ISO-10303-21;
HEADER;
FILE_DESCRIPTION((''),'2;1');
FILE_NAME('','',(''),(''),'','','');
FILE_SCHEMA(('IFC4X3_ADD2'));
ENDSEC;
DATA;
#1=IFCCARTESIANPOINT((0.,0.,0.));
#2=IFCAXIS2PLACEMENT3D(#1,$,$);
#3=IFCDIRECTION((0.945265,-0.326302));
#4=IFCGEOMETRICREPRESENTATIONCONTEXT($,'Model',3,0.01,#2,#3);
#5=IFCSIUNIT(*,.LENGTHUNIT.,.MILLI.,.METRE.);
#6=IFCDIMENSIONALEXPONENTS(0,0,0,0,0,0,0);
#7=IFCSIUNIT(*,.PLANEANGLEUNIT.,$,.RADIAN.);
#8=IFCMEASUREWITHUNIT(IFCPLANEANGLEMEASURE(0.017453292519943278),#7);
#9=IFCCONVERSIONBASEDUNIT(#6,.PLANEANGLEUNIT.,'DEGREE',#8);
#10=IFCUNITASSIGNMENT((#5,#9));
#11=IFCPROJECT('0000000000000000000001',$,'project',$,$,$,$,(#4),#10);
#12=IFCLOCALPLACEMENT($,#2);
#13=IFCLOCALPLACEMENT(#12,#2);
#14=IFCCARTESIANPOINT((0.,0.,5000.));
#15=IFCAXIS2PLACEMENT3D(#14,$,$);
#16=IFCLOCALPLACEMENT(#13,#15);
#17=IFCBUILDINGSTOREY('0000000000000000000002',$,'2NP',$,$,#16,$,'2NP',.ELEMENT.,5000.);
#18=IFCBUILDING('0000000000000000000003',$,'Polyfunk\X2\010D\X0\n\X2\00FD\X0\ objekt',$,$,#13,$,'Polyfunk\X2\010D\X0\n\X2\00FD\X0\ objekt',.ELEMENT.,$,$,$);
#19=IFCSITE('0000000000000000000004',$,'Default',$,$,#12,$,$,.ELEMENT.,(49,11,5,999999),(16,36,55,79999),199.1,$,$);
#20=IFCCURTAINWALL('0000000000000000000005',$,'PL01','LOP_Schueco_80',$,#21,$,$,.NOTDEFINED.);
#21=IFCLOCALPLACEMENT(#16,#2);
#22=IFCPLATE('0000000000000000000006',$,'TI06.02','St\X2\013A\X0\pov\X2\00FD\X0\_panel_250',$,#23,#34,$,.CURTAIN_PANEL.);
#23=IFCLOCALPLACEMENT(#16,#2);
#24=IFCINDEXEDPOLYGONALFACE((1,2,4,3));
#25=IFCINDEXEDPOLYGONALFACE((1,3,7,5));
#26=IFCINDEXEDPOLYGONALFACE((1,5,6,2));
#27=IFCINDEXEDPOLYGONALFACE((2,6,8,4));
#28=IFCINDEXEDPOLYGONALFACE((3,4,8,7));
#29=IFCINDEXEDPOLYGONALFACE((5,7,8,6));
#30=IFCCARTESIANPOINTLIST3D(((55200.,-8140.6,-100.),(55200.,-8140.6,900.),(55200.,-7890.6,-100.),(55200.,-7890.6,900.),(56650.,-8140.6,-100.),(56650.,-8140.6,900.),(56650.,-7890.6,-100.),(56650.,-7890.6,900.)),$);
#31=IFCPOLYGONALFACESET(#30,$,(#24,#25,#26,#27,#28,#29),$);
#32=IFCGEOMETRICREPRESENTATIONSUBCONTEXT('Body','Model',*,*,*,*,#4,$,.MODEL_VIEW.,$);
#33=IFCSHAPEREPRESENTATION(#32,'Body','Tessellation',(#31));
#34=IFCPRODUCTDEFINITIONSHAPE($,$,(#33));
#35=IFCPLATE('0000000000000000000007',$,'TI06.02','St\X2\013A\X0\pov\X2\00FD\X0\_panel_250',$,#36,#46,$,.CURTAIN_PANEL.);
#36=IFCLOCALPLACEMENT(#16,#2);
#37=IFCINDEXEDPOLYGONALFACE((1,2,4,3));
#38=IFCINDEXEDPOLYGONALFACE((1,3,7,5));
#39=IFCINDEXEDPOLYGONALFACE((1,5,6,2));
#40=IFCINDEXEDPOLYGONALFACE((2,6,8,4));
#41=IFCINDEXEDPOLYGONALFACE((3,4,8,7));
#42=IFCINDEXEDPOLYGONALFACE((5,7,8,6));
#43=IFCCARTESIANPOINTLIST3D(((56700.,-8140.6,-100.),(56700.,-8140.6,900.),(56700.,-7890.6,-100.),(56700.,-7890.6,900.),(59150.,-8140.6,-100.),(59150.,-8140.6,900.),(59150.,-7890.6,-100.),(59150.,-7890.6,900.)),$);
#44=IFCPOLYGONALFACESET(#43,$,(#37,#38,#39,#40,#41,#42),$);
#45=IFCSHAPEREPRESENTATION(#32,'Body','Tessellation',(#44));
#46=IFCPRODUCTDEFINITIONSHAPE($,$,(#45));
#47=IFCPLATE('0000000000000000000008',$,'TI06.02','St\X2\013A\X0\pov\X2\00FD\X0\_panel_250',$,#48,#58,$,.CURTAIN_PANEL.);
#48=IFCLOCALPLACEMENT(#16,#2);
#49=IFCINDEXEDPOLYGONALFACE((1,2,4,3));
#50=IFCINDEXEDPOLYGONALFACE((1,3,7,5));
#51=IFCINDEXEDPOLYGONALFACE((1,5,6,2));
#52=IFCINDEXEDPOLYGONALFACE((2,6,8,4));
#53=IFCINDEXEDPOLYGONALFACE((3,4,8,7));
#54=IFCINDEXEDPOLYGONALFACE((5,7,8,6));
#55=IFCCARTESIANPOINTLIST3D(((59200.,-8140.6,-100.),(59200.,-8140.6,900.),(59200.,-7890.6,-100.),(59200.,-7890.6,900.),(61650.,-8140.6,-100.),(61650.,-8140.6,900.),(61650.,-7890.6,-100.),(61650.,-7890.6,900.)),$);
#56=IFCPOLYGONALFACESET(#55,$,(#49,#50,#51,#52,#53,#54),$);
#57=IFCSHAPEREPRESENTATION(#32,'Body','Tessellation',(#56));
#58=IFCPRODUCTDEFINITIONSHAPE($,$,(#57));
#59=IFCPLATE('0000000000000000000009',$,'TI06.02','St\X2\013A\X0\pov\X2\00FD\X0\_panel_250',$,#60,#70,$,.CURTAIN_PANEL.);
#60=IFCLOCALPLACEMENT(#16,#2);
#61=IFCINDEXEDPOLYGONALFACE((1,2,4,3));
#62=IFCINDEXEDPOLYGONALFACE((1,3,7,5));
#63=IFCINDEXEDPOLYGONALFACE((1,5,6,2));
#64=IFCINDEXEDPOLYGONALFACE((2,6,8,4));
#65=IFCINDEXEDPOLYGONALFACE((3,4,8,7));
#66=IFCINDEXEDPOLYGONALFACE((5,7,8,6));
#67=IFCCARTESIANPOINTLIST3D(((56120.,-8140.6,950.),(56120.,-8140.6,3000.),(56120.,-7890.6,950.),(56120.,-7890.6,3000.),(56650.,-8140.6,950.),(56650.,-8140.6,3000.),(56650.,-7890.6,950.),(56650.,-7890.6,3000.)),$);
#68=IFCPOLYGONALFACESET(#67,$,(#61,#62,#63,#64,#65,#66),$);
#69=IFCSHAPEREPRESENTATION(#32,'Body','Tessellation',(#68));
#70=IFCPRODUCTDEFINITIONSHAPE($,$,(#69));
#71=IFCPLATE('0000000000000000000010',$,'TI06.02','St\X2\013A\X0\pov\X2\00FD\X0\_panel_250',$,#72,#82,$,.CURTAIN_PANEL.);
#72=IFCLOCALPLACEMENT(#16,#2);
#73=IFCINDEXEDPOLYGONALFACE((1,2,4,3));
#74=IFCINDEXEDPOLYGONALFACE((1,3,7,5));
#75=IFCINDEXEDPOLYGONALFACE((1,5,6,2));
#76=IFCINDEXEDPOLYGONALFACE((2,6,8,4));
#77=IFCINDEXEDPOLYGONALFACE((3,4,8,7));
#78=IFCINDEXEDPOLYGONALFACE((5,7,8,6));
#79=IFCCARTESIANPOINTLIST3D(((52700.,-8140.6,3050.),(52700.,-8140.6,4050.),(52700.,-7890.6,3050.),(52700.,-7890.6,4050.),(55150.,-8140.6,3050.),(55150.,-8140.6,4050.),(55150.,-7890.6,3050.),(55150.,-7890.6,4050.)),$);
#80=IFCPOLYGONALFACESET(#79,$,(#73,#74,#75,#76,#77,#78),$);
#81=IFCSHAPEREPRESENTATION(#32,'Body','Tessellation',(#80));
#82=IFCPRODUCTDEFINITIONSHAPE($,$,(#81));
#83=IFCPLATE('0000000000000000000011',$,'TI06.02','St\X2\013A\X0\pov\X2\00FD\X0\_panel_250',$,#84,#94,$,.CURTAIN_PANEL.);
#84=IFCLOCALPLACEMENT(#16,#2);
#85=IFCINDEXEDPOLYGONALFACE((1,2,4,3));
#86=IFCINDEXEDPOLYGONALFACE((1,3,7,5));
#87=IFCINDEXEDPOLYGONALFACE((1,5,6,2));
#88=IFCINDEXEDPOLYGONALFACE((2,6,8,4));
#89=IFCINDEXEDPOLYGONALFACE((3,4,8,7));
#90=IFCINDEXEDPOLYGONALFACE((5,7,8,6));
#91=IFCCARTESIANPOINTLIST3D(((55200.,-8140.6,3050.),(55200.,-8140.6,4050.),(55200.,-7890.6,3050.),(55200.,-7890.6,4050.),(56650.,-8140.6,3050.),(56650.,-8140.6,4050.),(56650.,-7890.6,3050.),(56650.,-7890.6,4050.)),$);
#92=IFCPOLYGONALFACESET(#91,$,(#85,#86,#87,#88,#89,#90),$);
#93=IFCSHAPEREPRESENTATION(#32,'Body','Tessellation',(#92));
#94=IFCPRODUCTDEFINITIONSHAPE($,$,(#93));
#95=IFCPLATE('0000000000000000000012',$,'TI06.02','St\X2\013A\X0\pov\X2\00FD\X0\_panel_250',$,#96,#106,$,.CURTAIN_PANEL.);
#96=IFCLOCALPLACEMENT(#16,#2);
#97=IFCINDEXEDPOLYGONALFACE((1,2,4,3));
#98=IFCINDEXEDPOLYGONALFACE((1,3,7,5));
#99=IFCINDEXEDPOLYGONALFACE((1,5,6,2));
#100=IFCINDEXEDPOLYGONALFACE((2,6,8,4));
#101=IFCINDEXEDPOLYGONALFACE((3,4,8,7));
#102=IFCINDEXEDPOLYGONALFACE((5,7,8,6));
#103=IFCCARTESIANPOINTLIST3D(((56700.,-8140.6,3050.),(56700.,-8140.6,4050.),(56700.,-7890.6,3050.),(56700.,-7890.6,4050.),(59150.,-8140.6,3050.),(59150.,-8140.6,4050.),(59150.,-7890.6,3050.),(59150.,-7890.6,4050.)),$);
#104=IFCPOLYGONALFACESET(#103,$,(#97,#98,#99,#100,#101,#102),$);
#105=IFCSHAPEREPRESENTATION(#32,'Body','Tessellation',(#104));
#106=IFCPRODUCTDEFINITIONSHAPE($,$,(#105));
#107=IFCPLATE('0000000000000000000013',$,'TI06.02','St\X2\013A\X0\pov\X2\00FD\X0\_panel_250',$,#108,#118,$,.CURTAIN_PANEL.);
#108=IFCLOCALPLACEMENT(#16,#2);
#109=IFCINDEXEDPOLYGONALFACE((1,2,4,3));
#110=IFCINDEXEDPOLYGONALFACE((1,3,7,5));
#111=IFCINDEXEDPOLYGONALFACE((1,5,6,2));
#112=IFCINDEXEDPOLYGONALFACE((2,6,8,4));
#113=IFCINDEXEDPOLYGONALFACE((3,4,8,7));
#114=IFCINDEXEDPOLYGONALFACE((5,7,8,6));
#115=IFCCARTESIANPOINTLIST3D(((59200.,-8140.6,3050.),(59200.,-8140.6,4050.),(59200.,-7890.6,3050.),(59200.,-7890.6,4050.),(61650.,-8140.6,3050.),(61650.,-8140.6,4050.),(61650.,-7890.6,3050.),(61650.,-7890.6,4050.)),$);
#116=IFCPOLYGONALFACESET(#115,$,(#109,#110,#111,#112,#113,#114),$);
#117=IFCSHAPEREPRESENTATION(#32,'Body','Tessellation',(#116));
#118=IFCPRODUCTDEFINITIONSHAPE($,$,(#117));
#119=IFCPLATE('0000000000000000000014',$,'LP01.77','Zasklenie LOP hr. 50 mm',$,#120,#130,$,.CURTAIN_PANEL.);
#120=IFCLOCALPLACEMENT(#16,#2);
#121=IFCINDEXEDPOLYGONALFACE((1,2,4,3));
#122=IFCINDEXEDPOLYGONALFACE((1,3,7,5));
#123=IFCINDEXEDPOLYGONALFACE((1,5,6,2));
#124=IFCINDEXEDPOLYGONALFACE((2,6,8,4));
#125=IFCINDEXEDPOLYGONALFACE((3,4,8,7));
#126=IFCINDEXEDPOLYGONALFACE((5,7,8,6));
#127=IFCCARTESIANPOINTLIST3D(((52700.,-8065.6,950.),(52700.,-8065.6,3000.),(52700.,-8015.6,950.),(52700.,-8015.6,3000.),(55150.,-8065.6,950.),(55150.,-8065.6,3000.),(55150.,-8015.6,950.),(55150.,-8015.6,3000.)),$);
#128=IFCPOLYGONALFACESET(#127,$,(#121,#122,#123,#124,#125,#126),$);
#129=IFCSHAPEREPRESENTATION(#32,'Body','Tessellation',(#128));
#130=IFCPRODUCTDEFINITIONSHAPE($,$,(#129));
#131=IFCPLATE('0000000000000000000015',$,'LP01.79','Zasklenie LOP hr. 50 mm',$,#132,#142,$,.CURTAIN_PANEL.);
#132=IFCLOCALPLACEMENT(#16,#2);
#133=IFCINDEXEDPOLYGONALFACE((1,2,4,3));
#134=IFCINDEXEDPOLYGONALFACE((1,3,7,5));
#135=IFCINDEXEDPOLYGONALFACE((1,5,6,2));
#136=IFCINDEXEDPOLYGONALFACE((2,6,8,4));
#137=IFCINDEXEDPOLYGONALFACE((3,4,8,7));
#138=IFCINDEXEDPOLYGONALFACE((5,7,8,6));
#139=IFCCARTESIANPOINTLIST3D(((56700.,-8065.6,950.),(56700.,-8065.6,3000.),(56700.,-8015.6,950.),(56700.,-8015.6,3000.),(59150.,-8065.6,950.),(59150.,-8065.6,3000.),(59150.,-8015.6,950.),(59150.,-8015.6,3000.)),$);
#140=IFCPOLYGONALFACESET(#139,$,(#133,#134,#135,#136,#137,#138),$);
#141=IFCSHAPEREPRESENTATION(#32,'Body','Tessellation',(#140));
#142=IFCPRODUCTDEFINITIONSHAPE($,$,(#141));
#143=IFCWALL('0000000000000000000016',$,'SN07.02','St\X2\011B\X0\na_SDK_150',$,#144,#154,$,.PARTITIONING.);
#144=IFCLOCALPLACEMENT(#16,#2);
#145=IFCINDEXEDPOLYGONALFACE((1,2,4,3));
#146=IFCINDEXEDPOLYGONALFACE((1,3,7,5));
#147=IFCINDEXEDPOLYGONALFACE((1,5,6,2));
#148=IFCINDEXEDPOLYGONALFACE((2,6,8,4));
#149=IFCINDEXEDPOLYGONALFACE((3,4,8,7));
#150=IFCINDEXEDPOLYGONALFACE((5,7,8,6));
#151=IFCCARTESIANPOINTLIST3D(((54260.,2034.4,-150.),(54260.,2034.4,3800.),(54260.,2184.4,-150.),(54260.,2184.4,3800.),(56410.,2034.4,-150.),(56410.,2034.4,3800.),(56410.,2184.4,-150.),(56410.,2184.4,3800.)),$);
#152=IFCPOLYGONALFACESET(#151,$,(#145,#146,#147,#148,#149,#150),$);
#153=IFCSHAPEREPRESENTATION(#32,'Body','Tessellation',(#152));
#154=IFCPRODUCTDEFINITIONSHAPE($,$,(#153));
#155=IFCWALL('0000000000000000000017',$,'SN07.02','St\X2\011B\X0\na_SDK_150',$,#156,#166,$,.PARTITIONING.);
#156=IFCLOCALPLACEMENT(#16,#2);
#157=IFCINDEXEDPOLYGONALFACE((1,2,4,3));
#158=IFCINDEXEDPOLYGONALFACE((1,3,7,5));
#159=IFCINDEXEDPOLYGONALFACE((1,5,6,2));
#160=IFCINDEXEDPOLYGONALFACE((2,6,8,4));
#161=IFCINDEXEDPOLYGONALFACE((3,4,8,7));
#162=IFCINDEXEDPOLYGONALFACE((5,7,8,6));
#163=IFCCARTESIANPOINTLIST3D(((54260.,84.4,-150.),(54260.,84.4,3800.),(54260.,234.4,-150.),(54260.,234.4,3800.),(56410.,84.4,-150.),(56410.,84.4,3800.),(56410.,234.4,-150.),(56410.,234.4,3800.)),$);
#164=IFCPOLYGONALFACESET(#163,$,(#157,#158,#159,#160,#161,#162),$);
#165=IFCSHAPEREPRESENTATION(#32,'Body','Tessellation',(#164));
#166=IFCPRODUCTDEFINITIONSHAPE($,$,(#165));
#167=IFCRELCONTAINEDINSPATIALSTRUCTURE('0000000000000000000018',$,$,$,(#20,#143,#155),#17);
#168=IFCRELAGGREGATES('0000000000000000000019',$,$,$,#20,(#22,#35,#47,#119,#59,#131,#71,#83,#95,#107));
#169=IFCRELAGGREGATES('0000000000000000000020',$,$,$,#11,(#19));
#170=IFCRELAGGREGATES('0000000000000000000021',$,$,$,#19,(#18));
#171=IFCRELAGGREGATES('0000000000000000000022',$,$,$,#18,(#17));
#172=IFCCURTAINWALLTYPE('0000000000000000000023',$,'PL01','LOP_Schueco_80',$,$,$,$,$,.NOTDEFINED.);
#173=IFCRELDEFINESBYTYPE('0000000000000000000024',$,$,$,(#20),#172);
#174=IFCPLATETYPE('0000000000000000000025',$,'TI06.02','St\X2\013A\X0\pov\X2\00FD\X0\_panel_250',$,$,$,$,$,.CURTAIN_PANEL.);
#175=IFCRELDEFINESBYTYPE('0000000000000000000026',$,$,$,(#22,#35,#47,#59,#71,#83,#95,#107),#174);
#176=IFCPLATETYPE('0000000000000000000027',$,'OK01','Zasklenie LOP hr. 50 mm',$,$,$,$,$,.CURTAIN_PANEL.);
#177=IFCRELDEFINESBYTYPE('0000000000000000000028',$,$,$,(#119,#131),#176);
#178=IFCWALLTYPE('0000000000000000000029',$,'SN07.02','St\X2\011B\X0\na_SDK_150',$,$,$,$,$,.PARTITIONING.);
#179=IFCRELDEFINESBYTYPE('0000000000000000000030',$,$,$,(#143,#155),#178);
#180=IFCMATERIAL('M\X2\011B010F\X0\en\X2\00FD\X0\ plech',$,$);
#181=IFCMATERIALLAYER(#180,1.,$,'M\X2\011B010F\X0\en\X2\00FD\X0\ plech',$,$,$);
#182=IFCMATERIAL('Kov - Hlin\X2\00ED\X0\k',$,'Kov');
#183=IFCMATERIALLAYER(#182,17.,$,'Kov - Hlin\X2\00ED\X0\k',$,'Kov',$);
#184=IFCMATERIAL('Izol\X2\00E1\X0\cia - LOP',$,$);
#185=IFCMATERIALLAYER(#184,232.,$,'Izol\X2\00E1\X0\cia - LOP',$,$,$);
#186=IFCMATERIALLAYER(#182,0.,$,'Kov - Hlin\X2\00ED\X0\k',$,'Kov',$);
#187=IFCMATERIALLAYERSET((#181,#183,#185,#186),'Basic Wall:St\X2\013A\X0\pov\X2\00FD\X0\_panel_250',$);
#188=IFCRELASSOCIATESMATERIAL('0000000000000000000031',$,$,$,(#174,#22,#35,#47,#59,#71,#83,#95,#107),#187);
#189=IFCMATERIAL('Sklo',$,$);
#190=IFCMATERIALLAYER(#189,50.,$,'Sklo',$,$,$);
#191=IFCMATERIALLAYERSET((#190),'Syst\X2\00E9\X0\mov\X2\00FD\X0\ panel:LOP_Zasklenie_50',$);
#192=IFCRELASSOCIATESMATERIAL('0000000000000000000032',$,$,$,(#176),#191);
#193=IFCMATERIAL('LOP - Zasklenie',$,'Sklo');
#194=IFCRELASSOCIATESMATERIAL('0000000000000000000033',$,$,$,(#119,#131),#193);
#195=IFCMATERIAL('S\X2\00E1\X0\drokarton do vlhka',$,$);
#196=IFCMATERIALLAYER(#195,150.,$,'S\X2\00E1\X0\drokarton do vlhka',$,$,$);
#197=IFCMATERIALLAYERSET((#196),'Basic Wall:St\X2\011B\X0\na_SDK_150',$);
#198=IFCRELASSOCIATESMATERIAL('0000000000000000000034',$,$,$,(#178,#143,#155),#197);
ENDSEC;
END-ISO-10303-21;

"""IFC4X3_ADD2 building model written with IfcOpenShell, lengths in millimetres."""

from ifc_helpers import new_model, entity, si_unit, converted_unit, direction, frame, frame_2d, origin, origin_2d_with_axis, place, context, subcontext, project, spatial, polyline, rectangle, extrude, clip, bounded_halfspace, source, transform, mapped, material, layer, layer_set, layer_usage, type_object, type_shapes, element, aggregate, save


model = new_model("IFC4X3_ADD2")

# Units and contexts
model_context = context("Model", 3, precision=0.01, world=origin(), true_north=direction((0.945265, -0.326302)))
body_context = subcontext(model_context, "Body", "Model", "MODEL_VIEW")
ifc_project = project(units=[si_unit("LENGTHUNIT", "METRE", prefix="MILLI"), converted_unit("PLANEANGLEUNIT", "DEGREE", entity("IfcPlaneAngleMeasure", 0.017453292519943278), si_unit("PLANEANGLEUNIT", "RADIAN"), dimensions=[0, 0, 0, 0, 0, 0, 0])], contexts=[model_context])

# Site, building, storey
site_placement = place(None, origin())
site = spatial("IfcSite", under=ifc_project, at=site_placement, Name="Default", CompositionType="ELEMENT", RefLatitude=(49, 11, 5, 999999), RefLongitude=(16, 36, 55, 79999), RefElevation=199.1)
building_placement = place(site_placement, origin())
building = spatial("IfcBuilding", under=site, at=building_placement, Name="Polyfunkčný objekt", LongName="Polyfunkčný objekt", CompositionType="ELEMENT")
storey_placement = place(building_placement, frame((0.0, 0.0, 5000.0)))
storey = spatial("IfcBuildingStorey", under=building, at=storey_placement, Name="2NP", LongName="2NP", CompositionType="ELEMENT", Elevation=5000.0)

# Curtain wall, plates
curtain_wall_type = type_object("IfcCurtainWallType", Name="PL01", Description="LOP_Schueco_80", PredefinedType="NOTDEFINED")
curtain_wall_placement = place(storey_placement, frame((0.0, 0.0, -5000.0)))
curtain_wall = element("IfcCurtainWall", 1, at=curtain_wall_placement, inside=storey, type_object=curtain_wall_type, Name="PL01", Description="LOP_Schueco_80", PredefinedType="NOTDEFINED")
ifc_material_1 = material(Name="Měďený plech")
ifc_layer_1 = layer(ifc_material_1, 1.0, Name="Měďený plech")
ifc_material_2 = material(Name="Kov - Hliník", Category="Kov")
ifc_layer_2 = layer(ifc_material_2, 17.0, Name="Kov - Hliník", Category="Kov")
ifc_material_3 = material(Name="Izolácia - LOP")
ifc_layer_3 = layer(ifc_material_3, 232.0, Name="Izolácia - LOP")
ifc_layer_4 = layer(ifc_material_2, 0.0, Name="Kov - Hliník", Category="Kov")
ifc_layer_set_1 = layer_set([ifc_layer_1, ifc_layer_2, ifc_layer_3, ifc_layer_4], Name="Basic Wall:Stĺpový_panel_250")
ifc_layer_usage_1 = layer_usage(ifc_layer_set_1, "AXIS2", "POSITIVE", -125.0)
plate_type_1 = type_object("IfcPlateType", Name="TI06.02", Description="Stĺpový_panel_250", PredefinedType="CURTAIN_PANEL", material=ifc_layer_set_1)
plate_1_placement = place(storey_placement, frame((55200.0, -8015.6, -100.0)))
plate_1 = element("IfcPlate", 2, at=plate_1_placement, type_object=plate_type_1, material=ifc_layer_usage_1, Name="TI06.02", Description="Stĺpový_panel_250", PredefinedType="CURTAIN_PANEL", context=body_context, shape_type="SweptSolid", body=[
    extrude(rectangle(XDim=250.0, YDim=1450.0, at=frame_2d((0.0, 0.0), x_axis=(1.0, 0.0))), frame((725.0, 0.0, 0.0), z_axis=(0.0, 0.0, 1.0), x_axis=(0.0, 1.0, 0.0)), (0.0, 0.0, 1.0), 1000.0),
])
ifc_layer_usage_2 = layer_usage(ifc_layer_set_1, "AXIS2", "POSITIVE", -125.0)
plate_2_placement = place(storey_placement, frame((56700.0, -8015.6, -100.0)))
plate_2 = element("IfcPlate", 3, at=plate_2_placement, type_object=plate_type_1, material=ifc_layer_usage_2, Name="TI06.02", Description="Stĺpový_panel_250", PredefinedType="CURTAIN_PANEL", context=body_context, shape_type="SweptSolid", body=[
    extrude(rectangle(XDim=250.0, YDim=2450.0, at=frame_2d((0.0, 0.0), x_axis=(1.0, 0.0))), frame((1225.0, 0.0, 0.0), z_axis=(0.0, 0.0, 1.0), x_axis=(0.0, 1.0, 0.0)), (0.0, 0.0, 1.0), 1000.0),
])
ifc_layer_usage_3 = layer_usage(ifc_layer_set_1, "AXIS2", "POSITIVE", -125.0)
plate_3_placement = place(storey_placement, frame((59200.0, -8015.6, -100.0)))
plate_3 = element("IfcPlate", 4, at=plate_3_placement, type_object=plate_type_1, material=ifc_layer_usage_3, Name="TI06.02", Description="Stĺpový_panel_250", PredefinedType="CURTAIN_PANEL", context=body_context, shape_type="SweptSolid", body=[
    extrude(rectangle(XDim=250.0, YDim=2450.0, at=frame_2d((0.0, 0.0), x_axis=(1.0, 0.0))), frame((1225.0, 0.0, 0.0), z_axis=(0.0, 0.0, 1.0), x_axis=(0.0, 1.0, 0.0)), (0.0, 0.0, 1.0), 1000.0),
])
ifc_layer_usage_4 = layer_usage(ifc_layer_set_1, "AXIS2", "POSITIVE", -125.0)
plate_4_placement = place(storey_placement, frame((56120.0, -8015.6, 950.0)))
plate_4 = element("IfcPlate", 5, at=plate_4_placement, type_object=plate_type_1, material=ifc_layer_usage_4, Name="TI06.02", Description="Stĺpový_panel_250", PredefinedType="CURTAIN_PANEL", context=body_context, shape_type="SweptSolid", body=[
    extrude(rectangle(XDim=250.0, YDim=530.0, at=origin_2d_with_axis()), frame((265.0, 0.0, 0.0), z_axis=(0.0, 0.0, 1.0), x_axis=(0.0, 1.0, 0.0)), (0.0, 0.0, 1.0), 2050.0),
])
ifc_layer_usage_5 = layer_usage(ifc_layer_set_1, "AXIS2", "POSITIVE", -125.0)
plate_5_placement = place(storey_placement, frame((52700.0, -8015.6, 3050.0)))
plate_5 = element("IfcPlate", 6, at=plate_5_placement, type_object=plate_type_1, material=ifc_layer_usage_5, Name="TI06.02", Description="Stĺpový_panel_250", PredefinedType="CURTAIN_PANEL", context=body_context, shape_type="SweptSolid", body=[
    extrude(rectangle(XDim=250.0, YDim=2450.0, at=frame_2d((0.0, 0.0), x_axis=(1.0, 0.0))), frame((1225.0, 0.0, 0.0), z_axis=(0.0, 0.0, 1.0), x_axis=(0.0, 1.0, 0.0)), (0.0, 0.0, 1.0), 1000.0),
])
ifc_layer_usage_6 = layer_usage(ifc_layer_set_1, "AXIS2", "POSITIVE", -125.0)
plate_6_placement = place(storey_placement, frame((55200.0, -8015.6, 3050.0)))
plate_6 = element("IfcPlate", 7, at=plate_6_placement, type_object=plate_type_1, material=ifc_layer_usage_6, Name="TI06.02", Description="Stĺpový_panel_250", PredefinedType="CURTAIN_PANEL", context=body_context, shape_type="SweptSolid", body=[
    extrude(rectangle(XDim=250.0, YDim=1450.0, at=frame_2d((0.0, 0.0), x_axis=(1.0, 0.0))), frame((725.0, 0.0, 0.0), z_axis=(0.0, 0.0, 1.0), x_axis=(0.0, 1.0, 0.0)), (0.0, 0.0, 1.0), 1000.0),
])
ifc_layer_usage_7 = layer_usage(ifc_layer_set_1, "AXIS2", "POSITIVE", -125.0)
plate_7_placement = place(storey_placement, frame((56700.0, -8015.6, 3050.0)))
plate_7 = element("IfcPlate", 8, at=plate_7_placement, type_object=plate_type_1, material=ifc_layer_usage_7, Name="TI06.02", Description="Stĺpový_panel_250", PredefinedType="CURTAIN_PANEL", context=body_context, shape_type="SweptSolid", body=[
    extrude(rectangle(XDim=250.0, YDim=2450.0, at=frame_2d((0.0, 0.0), x_axis=(1.0, 0.0))), frame((1225.0, 0.0, 0.0), z_axis=(0.0, 0.0, 1.0), x_axis=(0.0, 1.0, 0.0)), (0.0, 0.0, 1.0), 1000.0),
])
ifc_layer_usage_8 = layer_usage(ifc_layer_set_1, "AXIS2", "POSITIVE", -125.0)
plate_8_placement = place(storey_placement, frame((59200.0, -8015.6, 3050.0)))
plate_8 = element("IfcPlate", 9, at=plate_8_placement, type_object=plate_type_1, material=ifc_layer_usage_8, Name="TI06.02", Description="Stĺpový_panel_250", PredefinedType="CURTAIN_PANEL", context=body_context, shape_type="SweptSolid", body=[
    extrude(rectangle(XDim=250.0, YDim=2450.0, at=frame_2d((0.0, 0.0), x_axis=(1.0, 0.0))), frame((1225.0, 0.0, 0.0), z_axis=(0.0, 0.0, 1.0), x_axis=(0.0, 1.0, 0.0)), (0.0, 0.0, 1.0), 1000.0),
])
ifc_material_4 = material(Name="LOP - Zasklenie", Category="Sklo")
ifc_material_5 = material(Name="Sklo")
ifc_layer_5 = layer(ifc_material_5, 50.0, Name="Sklo")
ifc_layer_set_2 = layer_set([ifc_layer_5], Name="Systémový panel:LOP_Zasklenie_50")
plate_type_2 = type_object("IfcPlateType", Name="OK01", Description="Zasklenie LOP hr. 50 mm", PredefinedType="CURTAIN_PANEL", material=ifc_layer_set_2)
shared_shape_1 = source(origin(), body_context, "Body", "SweptSolid", [
    extrude(rectangle(XDim=50.0, YDim=2450.0, at=origin_2d_with_axis()), frame((0.0, -25.0, 0.0), z_axis=(0.0, 0.0, 1.0), x_axis=(0.0, 1.0, 0.0)), (0.0, 0.0, 1.0), 2050.0),
])
type_shapes(plate_type_2, [shared_shape_1])
plate_9_placement = place(curtain_wall_placement, frame((53925.0, -8015.6, 5950.0)))
plate_9 = element("IfcPlate", 10, at=plate_9_placement, type_object=plate_type_2, material=ifc_material_4, Name="LP01.77", Description="Zasklenie LOP hr. 50 mm", PredefinedType="CURTAIN_PANEL", context=body_context, shape_type="MappedRepresentation", body=[
    mapped(shared_shape_1, transform((0.0, 0.0, 0.0), scale=1.0)),
])
plate_10_placement = place(curtain_wall_placement, frame((57925.0, -8015.6, 5950.0)))
plate_10 = element("IfcPlate", 11, at=plate_10_placement, type_object=plate_type_2, material=ifc_material_4, Name="LP01.79", Description="Zasklenie LOP hr. 50 mm", PredefinedType="CURTAIN_PANEL", context=body_context, shape_type="MappedRepresentation", body=[
    mapped(shared_shape_1, transform((0.0, 0.0, 0.0), scale=1.0)),
])

# Walls
ifc_material_6 = material(Name="Sádrokarton do vlhka")
ifc_layer_6 = layer(ifc_material_6, 150.0, Name="Sádrokarton do vlhka")
ifc_layer_set_3 = layer_set([ifc_layer_6], Name="Basic Wall:Stěna_SDK_150")
wall_type_1 = type_object("IfcWallType", Name="SN07.02", Description="Stěna_SDK_150", PredefinedType="PARTITIONING", material=ifc_layer_set_3)
wall_1_placement = place(storey_placement, frame((56410.0, 2109.4, -150.0), z_axis=(0.0, 0.0, 1.0), x_axis=(-1.0, 0.0, 0.0)))
element("IfcWall", 12, at=wall_1_placement, inside=storey, type_object=wall_type_1, material=ifc_layer_set_3, Name="SN07.02", Description="Stěna_SDK_150", PredefinedType="PARTITIONING", context=body_context, shape_type="Clipping", body=[
    clip(clip(extrude(rectangle(XDim=2150.0, YDim=150.0, at=frame_2d((1075.0, 0.0), x_axis=(-1.0, 0.0))), origin(), (0.0, 0.0, 1.0), 3950.0), bounded_halfspace(frame((2150.0, -75.0, 0.0)), True, frame((2150.0, -75.0, 0.0)), polyline([(0.0, 0.0), (0.0, 150.0), (-2150.0, 150.0), (-2150.0, 0.0), (0.0, 0.0)]))), bounded_halfspace(frame((0.0, -75.0, 3950.0), z_axis=(0.0, 0.0, -1.0), x_axis=(-1.0, 0.0, 0.0)), True, frame((0.0, -75.0, 3950.0)), polyline([(0.0, 0.0), (2150.0, 0.0), (2150.0, 150.0), (0.0, 150.0), (0.0, 0.0)]))),
])
wall_2_placement = place(storey_placement, frame((56410.0, 159.4, -150.0), z_axis=(0.0, 0.0, 1.0), x_axis=(-1.0, 0.0, 0.0)))
element("IfcWall", 13, at=wall_2_placement, inside=storey, type_object=wall_type_1, material=ifc_layer_set_3, Name="SN07.02", Description="Stěna_SDK_150", PredefinedType="PARTITIONING", context=body_context, shape_type="Clipping", body=[
    clip(clip(extrude(rectangle(XDim=2150.0, YDim=150.0, at=frame_2d((1075.0, 0.0), x_axis=(-1.0, 0.0))), origin(), (0.0, 0.0, 1.0), 3950.0), bounded_halfspace(frame((2150.0, -75.0, 0.0)), True, frame((2150.0, -75.0, 0.0)), polyline([(0.0, 0.0), (0.0, 150.0), (-2150.0, 150.0), (-2150.0, 0.0), (0.0, 0.0)]))), bounded_halfspace(frame((0.0, -75.0, 3950.0), z_axis=(0.0, 0.0, -1.0), x_axis=(-1.0, 0.0, 0.0)), True, frame((0.0, -75.0, 3950.0)), polyline([(0.0, 0.0), (2150.0, 0.0), (2150.0, 150.0), (0.0, 150.0), (0.0, 0.0)]))),
])

aggregate(curtain_wall, [plate_1, plate_2, plate_3, plate_9, plate_4, plate_10, plate_5, plate_6, plate_7, plate_8])

save(model, "model.ifc")
